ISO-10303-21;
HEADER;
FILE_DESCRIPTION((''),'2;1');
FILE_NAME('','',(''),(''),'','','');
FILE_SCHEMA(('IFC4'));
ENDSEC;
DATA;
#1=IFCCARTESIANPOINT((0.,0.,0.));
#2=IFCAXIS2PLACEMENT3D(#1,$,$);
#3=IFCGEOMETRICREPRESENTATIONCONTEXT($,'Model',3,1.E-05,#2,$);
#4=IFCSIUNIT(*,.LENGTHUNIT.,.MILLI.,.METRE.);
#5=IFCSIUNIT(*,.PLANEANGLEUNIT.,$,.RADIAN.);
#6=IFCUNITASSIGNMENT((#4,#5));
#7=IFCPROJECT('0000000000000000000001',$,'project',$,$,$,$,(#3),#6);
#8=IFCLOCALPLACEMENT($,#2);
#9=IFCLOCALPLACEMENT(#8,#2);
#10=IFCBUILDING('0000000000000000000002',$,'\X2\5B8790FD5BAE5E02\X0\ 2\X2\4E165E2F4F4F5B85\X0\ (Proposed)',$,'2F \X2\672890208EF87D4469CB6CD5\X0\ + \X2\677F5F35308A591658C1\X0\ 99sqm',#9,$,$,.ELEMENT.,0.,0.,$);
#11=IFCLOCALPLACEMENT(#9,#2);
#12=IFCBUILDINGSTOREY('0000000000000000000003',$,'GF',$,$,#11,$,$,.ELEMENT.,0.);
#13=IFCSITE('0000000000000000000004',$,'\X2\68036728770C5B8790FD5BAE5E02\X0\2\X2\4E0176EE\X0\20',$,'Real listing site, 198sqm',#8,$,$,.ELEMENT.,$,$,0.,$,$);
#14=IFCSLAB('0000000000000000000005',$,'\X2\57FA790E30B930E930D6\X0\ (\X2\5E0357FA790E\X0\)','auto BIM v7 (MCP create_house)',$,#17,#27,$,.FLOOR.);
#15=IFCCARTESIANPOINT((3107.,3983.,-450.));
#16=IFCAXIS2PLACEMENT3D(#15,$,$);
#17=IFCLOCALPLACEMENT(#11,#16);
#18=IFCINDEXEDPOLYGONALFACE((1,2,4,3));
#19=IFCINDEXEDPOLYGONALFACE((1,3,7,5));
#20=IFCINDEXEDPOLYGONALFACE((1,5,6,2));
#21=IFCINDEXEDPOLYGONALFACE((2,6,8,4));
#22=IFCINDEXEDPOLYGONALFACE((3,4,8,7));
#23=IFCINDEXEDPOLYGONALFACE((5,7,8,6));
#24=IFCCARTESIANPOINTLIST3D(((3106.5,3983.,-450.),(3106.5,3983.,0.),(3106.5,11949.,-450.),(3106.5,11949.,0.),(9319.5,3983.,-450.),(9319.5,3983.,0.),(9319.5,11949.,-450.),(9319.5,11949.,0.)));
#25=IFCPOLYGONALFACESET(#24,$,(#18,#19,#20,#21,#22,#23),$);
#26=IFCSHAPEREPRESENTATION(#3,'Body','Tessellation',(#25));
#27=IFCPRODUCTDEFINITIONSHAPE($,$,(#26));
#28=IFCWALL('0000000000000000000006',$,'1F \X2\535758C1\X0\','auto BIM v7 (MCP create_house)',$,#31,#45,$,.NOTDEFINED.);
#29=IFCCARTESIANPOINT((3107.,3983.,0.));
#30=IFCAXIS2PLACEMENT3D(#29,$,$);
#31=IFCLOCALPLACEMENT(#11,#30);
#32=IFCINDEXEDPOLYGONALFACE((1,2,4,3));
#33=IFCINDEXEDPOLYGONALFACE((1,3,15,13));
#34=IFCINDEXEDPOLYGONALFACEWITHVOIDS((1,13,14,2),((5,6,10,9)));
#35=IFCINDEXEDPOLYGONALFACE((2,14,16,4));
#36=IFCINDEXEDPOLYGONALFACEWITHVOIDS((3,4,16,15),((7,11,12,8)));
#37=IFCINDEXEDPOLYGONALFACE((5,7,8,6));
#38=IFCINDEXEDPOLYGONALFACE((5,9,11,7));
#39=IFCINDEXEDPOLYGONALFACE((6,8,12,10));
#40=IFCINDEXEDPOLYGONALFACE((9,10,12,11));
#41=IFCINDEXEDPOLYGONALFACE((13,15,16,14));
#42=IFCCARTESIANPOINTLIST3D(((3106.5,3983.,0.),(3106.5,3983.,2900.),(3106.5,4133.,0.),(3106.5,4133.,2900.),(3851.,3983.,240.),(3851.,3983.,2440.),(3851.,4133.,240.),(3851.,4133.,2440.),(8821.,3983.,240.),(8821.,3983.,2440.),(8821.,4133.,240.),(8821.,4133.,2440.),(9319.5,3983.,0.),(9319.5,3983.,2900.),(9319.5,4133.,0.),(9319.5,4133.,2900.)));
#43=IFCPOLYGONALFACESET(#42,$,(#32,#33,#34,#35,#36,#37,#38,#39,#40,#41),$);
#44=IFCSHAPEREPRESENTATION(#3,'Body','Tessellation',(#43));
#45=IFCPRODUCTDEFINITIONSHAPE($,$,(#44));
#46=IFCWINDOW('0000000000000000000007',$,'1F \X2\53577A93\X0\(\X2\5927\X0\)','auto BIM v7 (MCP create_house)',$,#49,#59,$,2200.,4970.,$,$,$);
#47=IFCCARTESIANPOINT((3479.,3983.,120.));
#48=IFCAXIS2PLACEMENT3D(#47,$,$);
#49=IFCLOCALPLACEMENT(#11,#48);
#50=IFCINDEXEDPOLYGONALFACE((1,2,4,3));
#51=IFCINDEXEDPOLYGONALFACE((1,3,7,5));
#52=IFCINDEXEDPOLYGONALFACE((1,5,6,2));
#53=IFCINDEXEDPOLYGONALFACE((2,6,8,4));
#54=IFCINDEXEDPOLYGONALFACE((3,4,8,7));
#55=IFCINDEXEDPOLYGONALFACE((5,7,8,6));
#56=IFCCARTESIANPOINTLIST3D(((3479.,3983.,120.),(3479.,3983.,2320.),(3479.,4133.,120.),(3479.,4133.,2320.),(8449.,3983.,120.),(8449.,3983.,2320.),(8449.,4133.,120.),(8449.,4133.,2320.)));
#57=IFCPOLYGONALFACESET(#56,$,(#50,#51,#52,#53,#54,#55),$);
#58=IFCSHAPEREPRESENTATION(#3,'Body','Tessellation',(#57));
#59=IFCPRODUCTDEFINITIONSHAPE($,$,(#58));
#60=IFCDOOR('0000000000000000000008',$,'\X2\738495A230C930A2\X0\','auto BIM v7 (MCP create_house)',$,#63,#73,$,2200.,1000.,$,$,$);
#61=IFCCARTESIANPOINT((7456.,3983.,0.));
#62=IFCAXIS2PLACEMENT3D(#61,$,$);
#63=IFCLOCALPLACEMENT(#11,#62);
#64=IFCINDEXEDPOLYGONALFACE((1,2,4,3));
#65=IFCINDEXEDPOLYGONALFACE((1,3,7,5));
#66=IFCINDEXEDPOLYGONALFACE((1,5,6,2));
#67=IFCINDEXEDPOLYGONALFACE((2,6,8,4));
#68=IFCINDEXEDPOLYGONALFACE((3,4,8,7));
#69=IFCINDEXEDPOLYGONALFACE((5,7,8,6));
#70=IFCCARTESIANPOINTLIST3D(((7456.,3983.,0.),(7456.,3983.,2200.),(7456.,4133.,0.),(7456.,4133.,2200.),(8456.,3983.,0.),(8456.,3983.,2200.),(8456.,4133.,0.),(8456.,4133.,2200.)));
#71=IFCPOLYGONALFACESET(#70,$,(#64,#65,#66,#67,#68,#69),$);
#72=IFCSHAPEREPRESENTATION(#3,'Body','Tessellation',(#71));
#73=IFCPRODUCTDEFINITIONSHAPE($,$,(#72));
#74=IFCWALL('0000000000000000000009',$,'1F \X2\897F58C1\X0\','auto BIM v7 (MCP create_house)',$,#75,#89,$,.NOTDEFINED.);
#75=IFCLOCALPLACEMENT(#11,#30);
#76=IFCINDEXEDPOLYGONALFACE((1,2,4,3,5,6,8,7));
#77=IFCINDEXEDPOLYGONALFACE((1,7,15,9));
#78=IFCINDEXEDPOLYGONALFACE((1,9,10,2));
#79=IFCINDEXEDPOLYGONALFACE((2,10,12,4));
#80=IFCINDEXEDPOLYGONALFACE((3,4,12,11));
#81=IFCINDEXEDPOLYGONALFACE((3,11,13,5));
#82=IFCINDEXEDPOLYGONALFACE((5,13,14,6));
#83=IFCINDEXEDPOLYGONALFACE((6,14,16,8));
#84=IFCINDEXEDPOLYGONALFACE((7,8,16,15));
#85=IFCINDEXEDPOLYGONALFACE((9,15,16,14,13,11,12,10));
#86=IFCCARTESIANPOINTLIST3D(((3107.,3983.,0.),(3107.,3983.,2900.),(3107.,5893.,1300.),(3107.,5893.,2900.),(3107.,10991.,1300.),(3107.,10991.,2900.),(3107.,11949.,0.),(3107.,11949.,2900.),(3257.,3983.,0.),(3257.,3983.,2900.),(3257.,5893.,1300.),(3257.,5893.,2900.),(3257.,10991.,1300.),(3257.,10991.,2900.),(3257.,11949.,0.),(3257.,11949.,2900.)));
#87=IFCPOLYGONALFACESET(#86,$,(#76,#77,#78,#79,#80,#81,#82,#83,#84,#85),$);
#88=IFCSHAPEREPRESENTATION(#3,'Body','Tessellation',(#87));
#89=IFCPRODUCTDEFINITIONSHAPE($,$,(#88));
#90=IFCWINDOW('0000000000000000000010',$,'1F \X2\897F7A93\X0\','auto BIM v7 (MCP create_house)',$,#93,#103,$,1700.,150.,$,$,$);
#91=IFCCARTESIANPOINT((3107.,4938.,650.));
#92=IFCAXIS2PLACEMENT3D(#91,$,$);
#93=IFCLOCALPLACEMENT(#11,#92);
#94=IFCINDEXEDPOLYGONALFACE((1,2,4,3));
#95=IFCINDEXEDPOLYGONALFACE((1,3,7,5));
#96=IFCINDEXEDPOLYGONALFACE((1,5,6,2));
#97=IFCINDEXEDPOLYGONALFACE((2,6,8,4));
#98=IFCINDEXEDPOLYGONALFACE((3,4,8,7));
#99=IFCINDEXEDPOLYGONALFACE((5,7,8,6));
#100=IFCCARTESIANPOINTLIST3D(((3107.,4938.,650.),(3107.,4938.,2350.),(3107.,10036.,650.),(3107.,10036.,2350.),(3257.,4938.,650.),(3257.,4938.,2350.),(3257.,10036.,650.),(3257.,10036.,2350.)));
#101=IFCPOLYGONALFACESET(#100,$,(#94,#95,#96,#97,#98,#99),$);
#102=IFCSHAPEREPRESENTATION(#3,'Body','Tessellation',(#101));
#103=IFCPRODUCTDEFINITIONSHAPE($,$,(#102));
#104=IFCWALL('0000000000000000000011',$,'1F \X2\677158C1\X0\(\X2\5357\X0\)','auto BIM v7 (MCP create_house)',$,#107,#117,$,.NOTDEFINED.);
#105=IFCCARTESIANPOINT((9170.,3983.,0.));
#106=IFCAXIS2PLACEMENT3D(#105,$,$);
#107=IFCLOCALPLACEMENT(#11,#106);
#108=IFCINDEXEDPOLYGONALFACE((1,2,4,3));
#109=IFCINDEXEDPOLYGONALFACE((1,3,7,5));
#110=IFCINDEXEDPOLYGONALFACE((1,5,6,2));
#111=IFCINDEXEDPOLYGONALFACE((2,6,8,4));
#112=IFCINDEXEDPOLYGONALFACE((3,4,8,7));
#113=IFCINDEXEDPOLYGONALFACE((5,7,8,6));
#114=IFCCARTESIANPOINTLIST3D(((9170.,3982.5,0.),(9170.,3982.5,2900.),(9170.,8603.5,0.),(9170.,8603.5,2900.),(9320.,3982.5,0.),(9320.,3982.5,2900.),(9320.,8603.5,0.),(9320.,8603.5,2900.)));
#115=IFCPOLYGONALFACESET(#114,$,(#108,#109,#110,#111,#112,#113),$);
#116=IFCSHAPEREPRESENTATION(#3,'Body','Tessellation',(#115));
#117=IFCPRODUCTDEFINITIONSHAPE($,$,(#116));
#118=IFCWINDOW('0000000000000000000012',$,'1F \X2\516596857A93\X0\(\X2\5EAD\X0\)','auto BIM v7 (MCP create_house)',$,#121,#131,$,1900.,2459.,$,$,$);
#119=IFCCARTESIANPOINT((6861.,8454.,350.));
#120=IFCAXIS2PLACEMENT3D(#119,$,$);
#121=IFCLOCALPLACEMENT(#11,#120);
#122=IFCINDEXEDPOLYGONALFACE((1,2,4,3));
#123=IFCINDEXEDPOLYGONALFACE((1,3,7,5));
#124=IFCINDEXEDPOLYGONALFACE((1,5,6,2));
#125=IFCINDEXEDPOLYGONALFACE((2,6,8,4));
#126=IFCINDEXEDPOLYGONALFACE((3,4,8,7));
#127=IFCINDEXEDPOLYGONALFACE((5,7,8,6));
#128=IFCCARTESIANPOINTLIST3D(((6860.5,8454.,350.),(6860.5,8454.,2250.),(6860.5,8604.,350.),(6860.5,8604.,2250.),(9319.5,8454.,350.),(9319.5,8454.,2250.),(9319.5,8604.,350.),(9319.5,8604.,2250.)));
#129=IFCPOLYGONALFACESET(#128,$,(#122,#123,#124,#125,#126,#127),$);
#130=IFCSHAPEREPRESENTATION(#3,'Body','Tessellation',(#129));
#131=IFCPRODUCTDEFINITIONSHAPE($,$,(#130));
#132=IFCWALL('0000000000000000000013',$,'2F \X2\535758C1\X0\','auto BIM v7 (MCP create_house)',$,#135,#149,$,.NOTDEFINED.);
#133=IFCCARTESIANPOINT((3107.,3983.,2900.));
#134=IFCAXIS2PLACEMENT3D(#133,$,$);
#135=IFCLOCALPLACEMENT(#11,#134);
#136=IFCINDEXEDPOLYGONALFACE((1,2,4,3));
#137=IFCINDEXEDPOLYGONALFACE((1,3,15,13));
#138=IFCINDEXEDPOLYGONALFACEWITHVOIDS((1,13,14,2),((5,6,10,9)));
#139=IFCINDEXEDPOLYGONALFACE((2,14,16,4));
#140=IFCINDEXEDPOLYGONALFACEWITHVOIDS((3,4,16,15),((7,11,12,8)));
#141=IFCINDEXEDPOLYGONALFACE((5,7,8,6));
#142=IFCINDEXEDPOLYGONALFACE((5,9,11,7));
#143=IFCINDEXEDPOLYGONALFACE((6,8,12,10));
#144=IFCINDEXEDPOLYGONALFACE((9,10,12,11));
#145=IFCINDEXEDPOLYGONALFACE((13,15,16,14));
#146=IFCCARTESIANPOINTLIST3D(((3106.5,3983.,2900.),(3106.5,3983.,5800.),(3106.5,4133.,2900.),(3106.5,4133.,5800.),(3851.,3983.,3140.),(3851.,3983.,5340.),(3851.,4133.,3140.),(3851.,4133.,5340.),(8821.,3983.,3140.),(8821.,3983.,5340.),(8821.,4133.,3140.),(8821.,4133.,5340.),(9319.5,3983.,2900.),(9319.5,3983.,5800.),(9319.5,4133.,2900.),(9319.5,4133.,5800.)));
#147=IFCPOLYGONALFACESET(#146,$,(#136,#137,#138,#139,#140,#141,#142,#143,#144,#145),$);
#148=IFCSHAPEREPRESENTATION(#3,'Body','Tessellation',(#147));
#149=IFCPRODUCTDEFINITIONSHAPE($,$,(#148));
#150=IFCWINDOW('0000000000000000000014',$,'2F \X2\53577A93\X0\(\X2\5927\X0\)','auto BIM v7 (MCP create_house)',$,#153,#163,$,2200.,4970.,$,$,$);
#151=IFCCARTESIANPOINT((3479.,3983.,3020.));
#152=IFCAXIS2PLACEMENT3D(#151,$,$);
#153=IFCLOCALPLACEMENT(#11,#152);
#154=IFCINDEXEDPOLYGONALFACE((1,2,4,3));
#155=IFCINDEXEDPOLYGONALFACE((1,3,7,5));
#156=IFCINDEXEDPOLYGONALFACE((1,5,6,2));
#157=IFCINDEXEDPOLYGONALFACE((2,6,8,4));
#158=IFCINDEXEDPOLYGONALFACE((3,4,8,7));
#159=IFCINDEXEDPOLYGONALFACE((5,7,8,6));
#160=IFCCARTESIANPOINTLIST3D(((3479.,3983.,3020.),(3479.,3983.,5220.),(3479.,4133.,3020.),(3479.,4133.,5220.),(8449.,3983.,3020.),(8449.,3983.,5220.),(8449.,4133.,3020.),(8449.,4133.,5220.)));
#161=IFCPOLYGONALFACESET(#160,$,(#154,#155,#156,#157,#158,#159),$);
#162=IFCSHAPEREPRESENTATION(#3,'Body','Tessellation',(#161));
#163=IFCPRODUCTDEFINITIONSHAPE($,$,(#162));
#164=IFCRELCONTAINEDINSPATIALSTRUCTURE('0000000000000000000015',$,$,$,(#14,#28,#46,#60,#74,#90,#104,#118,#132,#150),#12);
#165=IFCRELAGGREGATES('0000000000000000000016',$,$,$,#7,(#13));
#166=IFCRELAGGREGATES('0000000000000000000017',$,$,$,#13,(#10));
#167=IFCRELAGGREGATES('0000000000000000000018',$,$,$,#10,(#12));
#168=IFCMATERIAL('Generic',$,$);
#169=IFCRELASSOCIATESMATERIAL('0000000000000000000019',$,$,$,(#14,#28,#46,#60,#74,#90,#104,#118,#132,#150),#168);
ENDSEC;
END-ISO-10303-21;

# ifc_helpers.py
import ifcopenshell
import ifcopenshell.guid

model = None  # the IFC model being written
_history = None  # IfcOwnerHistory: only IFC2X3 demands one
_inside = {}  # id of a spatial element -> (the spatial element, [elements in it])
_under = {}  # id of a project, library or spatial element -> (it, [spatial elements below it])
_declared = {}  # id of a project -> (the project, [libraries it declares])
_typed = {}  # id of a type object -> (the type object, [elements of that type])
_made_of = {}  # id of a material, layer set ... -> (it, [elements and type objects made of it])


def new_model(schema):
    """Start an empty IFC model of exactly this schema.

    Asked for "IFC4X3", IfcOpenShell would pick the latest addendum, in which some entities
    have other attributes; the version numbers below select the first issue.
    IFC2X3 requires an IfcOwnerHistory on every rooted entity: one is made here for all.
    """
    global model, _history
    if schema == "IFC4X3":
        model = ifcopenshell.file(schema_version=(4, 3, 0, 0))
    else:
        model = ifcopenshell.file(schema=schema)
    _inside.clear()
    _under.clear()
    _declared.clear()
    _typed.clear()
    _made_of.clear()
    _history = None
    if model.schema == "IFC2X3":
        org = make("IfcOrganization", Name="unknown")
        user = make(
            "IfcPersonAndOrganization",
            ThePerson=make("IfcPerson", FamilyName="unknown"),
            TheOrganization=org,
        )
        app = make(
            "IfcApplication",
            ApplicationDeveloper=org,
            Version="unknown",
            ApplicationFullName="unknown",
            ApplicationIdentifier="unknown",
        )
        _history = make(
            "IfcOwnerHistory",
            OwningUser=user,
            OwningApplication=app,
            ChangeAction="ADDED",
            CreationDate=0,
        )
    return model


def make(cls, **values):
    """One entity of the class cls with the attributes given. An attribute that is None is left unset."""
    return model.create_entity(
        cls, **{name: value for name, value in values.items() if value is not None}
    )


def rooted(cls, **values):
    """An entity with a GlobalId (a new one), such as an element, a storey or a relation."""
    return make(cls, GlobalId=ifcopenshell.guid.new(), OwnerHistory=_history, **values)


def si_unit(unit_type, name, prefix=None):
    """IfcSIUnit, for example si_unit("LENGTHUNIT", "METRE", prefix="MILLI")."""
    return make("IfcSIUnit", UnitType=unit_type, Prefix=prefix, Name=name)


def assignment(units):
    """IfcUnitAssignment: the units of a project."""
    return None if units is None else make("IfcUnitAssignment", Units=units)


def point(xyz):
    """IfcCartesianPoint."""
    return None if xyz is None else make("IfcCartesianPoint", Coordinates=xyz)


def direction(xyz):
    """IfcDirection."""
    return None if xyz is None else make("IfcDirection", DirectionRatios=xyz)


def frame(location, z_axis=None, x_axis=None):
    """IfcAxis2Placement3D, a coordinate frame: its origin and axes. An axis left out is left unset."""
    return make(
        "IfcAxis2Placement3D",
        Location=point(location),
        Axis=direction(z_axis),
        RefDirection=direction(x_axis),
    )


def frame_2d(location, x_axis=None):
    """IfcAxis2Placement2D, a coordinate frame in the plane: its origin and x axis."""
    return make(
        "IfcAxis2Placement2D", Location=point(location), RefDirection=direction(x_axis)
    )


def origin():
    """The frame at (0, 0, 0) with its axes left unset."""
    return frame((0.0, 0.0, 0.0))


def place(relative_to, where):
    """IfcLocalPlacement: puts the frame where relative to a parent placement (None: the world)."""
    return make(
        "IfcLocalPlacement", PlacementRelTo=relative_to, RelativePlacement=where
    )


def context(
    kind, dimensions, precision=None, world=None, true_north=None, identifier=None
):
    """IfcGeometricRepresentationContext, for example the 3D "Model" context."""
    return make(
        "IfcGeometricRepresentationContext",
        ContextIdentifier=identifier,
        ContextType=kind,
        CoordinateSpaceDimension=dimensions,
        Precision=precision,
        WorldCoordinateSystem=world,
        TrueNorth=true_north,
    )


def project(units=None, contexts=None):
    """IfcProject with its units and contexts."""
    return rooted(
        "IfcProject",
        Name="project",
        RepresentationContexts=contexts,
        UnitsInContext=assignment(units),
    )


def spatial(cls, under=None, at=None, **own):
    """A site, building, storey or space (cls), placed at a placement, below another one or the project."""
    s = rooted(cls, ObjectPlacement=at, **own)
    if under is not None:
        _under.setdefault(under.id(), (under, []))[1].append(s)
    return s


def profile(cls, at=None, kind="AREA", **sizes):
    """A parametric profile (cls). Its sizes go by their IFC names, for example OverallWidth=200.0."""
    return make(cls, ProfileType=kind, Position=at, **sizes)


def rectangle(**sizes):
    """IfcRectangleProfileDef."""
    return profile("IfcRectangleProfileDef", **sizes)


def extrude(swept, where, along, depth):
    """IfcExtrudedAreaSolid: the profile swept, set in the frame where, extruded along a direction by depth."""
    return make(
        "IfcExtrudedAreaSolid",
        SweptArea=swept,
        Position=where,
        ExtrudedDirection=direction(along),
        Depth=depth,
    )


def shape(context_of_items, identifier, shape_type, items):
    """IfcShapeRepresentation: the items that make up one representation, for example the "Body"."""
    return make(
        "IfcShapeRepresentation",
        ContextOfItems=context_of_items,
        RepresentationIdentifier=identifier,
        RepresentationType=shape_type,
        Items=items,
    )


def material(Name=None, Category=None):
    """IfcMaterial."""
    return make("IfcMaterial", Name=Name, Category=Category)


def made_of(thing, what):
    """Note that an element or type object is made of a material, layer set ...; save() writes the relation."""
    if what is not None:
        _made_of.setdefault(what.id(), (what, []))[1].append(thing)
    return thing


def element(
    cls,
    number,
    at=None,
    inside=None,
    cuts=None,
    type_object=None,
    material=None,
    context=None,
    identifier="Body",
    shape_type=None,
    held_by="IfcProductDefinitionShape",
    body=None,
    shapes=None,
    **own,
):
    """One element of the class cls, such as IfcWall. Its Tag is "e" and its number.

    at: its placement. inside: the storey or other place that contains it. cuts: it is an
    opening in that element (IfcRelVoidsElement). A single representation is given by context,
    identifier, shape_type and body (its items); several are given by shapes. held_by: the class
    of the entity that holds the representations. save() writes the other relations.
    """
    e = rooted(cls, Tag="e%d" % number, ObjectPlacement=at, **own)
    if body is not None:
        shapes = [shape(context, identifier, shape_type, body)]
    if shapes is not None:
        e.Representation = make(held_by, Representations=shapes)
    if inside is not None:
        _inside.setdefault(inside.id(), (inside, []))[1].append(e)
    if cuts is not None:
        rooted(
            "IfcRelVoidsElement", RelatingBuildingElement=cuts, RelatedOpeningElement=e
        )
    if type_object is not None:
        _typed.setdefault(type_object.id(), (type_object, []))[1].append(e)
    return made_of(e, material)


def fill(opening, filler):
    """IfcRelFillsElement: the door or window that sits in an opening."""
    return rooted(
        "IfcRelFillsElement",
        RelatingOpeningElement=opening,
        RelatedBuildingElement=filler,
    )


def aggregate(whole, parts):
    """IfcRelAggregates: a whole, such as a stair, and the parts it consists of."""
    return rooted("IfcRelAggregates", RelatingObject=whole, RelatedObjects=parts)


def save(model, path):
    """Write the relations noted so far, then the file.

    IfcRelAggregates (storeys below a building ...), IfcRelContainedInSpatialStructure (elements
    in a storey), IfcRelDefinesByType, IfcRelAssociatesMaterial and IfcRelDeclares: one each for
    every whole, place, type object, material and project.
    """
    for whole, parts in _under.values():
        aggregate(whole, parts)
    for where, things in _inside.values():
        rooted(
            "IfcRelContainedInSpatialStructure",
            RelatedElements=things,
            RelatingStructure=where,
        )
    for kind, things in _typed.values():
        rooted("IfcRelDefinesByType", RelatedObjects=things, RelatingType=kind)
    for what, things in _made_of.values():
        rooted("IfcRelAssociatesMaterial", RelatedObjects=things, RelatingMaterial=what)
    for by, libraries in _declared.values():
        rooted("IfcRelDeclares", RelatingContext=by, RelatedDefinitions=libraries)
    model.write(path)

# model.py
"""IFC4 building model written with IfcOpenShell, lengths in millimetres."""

from ifc_helpers import new_model, si_unit, frame, frame_2d, origin, place, context, project, spatial, rectangle, extrude, material, element, fill, save


model = new_model("IFC4")

# Units and contexts
model_context = context("Model", 3, precision=1e-05, world=origin())
ifc_project = project(units=[si_unit("LENGTHUNIT", "METRE", prefix="MILLI"), si_unit("PLANEANGLEUNIT", "RADIAN")], contexts=[model_context])

# Site, building, storey
site_placement = place(None, origin())
site = spatial("IfcSite", under=ifc_project, at=site_placement, Name="栃木県宇都宮市2丁目20", ObjectType="Real listing site, 198sqm", CompositionType="ELEMENT", RefElevation=0.0)
building_placement = place(site_placement, origin())
building = spatial("IfcBuilding", under=site, at=building_placement, Name="宇都宮市 2世帯住宅 (Proposed)", ObjectType="2F 木造軸組構法 + 板張り外壁 99sqm", CompositionType="ELEMENT", ElevationOfRefHeight=0.0, ElevationOfTerrain=0.0)
storey_placement = place(building_placement, origin())
storey = spatial("IfcBuildingStorey", under=building, at=storey_placement, Name="GF", CompositionType="ELEMENT", Elevation=0.0)

# Slab
ifc_material = material(Name="Generic")
slab_1_placement = place(storey_placement, frame((3107.0, 3983.0, -450.0)))
element("IfcSlab", 1, at=slab_1_placement, inside=storey, material=ifc_material, Name="基礎スラブ (布基礎)", Description="auto BIM v7 (MCP create_house)", PredefinedType="FLOOR", context=model_context, shape_type="SweptSolid", body=[
    extrude(rectangle(XDim=6213.0, YDim=7966.0, at=frame_2d((3106.0, 3983.0))), frame((3107.0, 3983.0, -450.0)), (0.0, 0.0, 1.0), 450.0),
])

# Wall, openings, window, door
wall_1_placement = place(storey_placement, frame((3107.0, 3983.0, 0.0)))
wall_1 = element("IfcWall", 2, at=wall_1_placement, inside=storey, material=ifc_material, Name="1F 南壁", Description="auto BIM v7 (MCP create_house)", PredefinedType="NOTDEFINED", context=model_context, shape_type="SweptSolid", body=[
    extrude(rectangle(XDim=6213.0, YDim=150.0, at=frame_2d((3106.0, 75.0))), frame((3107.0, 3983.0, 0.0)), (0.0, 0.0, 1.0), 2900.0),
])
opening_1_placement = place(storey_placement, frame((3479.0, 3983.0, 120.0)))
opening_1 = element("IfcOpeningElement", 3, at=opening_1_placement, cuts=wall_1, PredefinedType="NOTDEFINED", context=model_context, shape_type="SweptSolid", body=[
    extrude(rectangle(XDim=4970.0, YDim=150.0, at=frame_2d((2485.0, 75.0))), frame((3479.0, 3983.0, 120.0)), (0.0, 0.0, 1.0), 2200.0),
])
opening_2_placement = place(storey_placement, frame((7456.0, 3983.0, 0.0)))
opening_2 = element("IfcOpeningElement", 4, at=opening_2_placement, cuts=wall_1, PredefinedType="NOTDEFINED", context=model_context, shape_type="SweptSolid", body=[
    extrude(rectangle(XDim=1000.0, YDim=150.0, at=frame_2d((500.0, 75.0))), frame((7456.0, 3983.0, 0.0)), (0.0, 0.0, 1.0), 2200.0),
])
window_1_placement = place(storey_placement, frame((3479.0, 3983.0, 120.0)))
window_1 = element("IfcWindow", 5, at=window_1_placement, inside=storey, material=ifc_material, Name="1F 南窓(大)", Description="auto BIM v7 (MCP create_house)", OverallHeight=2200.0, OverallWidth=4970.0, context=model_context, shape_type="SweptSolid", body=[
    extrude(rectangle(XDim=4970.0, YDim=150.0, at=frame_2d((2485.0, 75.0))), frame((3479.0, 3983.0, 120.0)), (0.0, 0.0, 1.0), 2200.0),
])
fill(opening_1, window_1)
door_placement = place(storey_placement, frame((7456.0, 3983.0, 0.0)))
door = element("IfcDoor", 6, at=door_placement, inside=storey, material=ifc_material, Name="玄関ドア", Description="auto BIM v7 (MCP create_house)", OverallHeight=2200.0, OverallWidth=1000.0, context=model_context, shape_type="SweptSolid", body=[
    extrude(rectangle(XDim=1000.0, YDim=150.0, at=frame_2d((500.0, 75.0))), frame((7456.0, 3983.0, 0.0)), (0.0, 0.0, 1.0), 2200.0),
])
fill(opening_2, door)

# Walls, openings, windows
wall_2_placement = place(storey_placement, frame((3107.0, 3983.0, 0.0)))
wall_2 = element("IfcWall", 7, at=wall_2_placement, inside=storey, material=ifc_material, Name="1F 西壁", Description="auto BIM v7 (MCP create_house)", PredefinedType="NOTDEFINED", context=model_context, shape_type="SweptSolid", body=[
    extrude(rectangle(XDim=150.0, YDim=7966.0, at=frame_2d((75.0, 3983.0))), frame((3107.0, 3983.0, 0.0)), (0.0, 0.0, 1.0), 2900.0),
])
opening_3_placement = place(storey_placement, frame((3107.0, 4938.0, 650.0)))
opening_3 = element("IfcOpeningElement", 8, at=opening_3_placement, cuts=wall_2, PredefinedType="NOTDEFINED", context=model_context, shape_type="SweptSolid", body=[
    extrude(rectangle(XDim=150.0, YDim=5098.0, at=frame_2d((75.0, 2549.0))), frame((3107.0, 4938.0, 650.0)), (0.0, 0.0, 1.0), 1700.0),
])
window_2_placement = place(storey_placement, frame((3107.0, 4938.0, 650.0)))
window_2 = element("IfcWindow", 9, at=window_2_placement, inside=storey, material=ifc_material, Name="1F 西窓", Description="auto BIM v7 (MCP create_house)", OverallHeight=1700.0, OverallWidth=150.0, context=model_context, shape_type="SweptSolid", body=[
    extrude(rectangle(XDim=150.0, YDim=5098.0, at=frame_2d((75.0, 2549.0))), frame((3107.0, 4938.0, 650.0)), (0.0, 0.0, 1.0), 1700.0),
])
fill(opening_3, window_2)
wall_3_placement = place(storey_placement, frame((9170.0, 3983.0, 0.0)))
wall_3 = element("IfcWall", 10, at=wall_3_placement, inside=storey, material=ifc_material, Name="1F 東壁(南)", Description="auto BIM v7 (MCP create_house)", PredefinedType="NOTDEFINED", context=model_context, shape_type="SweptSolid", body=[
    extrude(rectangle(XDim=150.0, YDim=4621.0, at=frame_2d((75.0, 2310.0))), frame((9170.0, 3983.0, 0.0)), (0.0, 0.0, 1.0), 2900.0),
])
opening_4_placement = place(storey_placement, frame((6861.0, 8454.0, 350.0)))
opening_4 = element("IfcOpeningElement", 11, at=opening_4_placement, cuts=wall_3, PredefinedType="NOTDEFINED", context=model_context, shape_type="SweptSolid", body=[
    extrude(rectangle(XDim=2459.0, YDim=150.0, at=frame_2d((1229.0, 75.0))), frame((6861.0, 8454.0, 350.0)), (0.0, 0.0, 1.0), 1900.0),
])
window_3_placement = place(storey_placement, frame((6861.0, 8454.0, 350.0)))
window_3 = element("IfcWindow", 12, at=window_3_placement, inside=storey, material=ifc_material, Name="1F 入隅窓(庭)", Description="auto BIM v7 (MCP create_house)", OverallHeight=1900.0, OverallWidth=2459.0, context=model_context, shape_type="SweptSolid", body=[
    extrude(rectangle(XDim=2459.0, YDim=150.0, at=frame_2d((1229.0, 75.0))), frame((6861.0, 8454.0, 350.0)), (0.0, 0.0, 1.0), 1900.0),
])
fill(opening_4, window_3)

# Wall, opening, window
wall_4_placement = place(storey_placement, frame((3107.0, 3983.0, 2900.0)))
wall_4 = element("IfcWall", 13, at=wall_4_placement, inside=storey, material=ifc_material, Name="2F 南壁", Description="auto BIM v7 (MCP create_house)", PredefinedType="NOTDEFINED", context=model_context, shape_type="SweptSolid", body=[
    extrude(rectangle(XDim=6213.0, YDim=150.0, at=frame_2d((3106.0, 75.0))), frame((3107.0, 3983.0, 2900.0)), (0.0, 0.0, 1.0), 2900.0),
])
opening_5_placement = place(storey_placement, frame((3479.0, 3983.0, 3020.0)))
opening_5 = element("IfcOpeningElement", 14, at=opening_5_placement, cuts=wall_4, PredefinedType="NOTDEFINED", context=model_context, shape_type="SweptSolid", body=[
    extrude(rectangle(XDim=4970.0, YDim=150.0, at=frame_2d((2485.0, 75.0))), frame((3479.0, 3983.0, 3020.0)), (0.0, 0.0, 1.0), 2200.0),
])
window_4_placement = place(storey_placement, frame((3479.0, 3983.0, 3020.0)))
window_4 = element("IfcWindow", 15, at=window_4_placement, inside=storey, material=ifc_material, Name="2F 南窓(大)", Description="auto BIM v7 (MCP create_house)", OverallHeight=2200.0, OverallWidth=4970.0, context=model_context, shape_type="SweptSolid", body=[
    extrude(rectangle(XDim=4970.0, YDim=150.0, at=frame_2d((2485.0, 75.0))), frame((3479.0, 3983.0, 3020.0)), (0.0, 0.0, 1.0), 2200.0),
])
fill(opening_5, window_4)

save(model, "model.ifc")
